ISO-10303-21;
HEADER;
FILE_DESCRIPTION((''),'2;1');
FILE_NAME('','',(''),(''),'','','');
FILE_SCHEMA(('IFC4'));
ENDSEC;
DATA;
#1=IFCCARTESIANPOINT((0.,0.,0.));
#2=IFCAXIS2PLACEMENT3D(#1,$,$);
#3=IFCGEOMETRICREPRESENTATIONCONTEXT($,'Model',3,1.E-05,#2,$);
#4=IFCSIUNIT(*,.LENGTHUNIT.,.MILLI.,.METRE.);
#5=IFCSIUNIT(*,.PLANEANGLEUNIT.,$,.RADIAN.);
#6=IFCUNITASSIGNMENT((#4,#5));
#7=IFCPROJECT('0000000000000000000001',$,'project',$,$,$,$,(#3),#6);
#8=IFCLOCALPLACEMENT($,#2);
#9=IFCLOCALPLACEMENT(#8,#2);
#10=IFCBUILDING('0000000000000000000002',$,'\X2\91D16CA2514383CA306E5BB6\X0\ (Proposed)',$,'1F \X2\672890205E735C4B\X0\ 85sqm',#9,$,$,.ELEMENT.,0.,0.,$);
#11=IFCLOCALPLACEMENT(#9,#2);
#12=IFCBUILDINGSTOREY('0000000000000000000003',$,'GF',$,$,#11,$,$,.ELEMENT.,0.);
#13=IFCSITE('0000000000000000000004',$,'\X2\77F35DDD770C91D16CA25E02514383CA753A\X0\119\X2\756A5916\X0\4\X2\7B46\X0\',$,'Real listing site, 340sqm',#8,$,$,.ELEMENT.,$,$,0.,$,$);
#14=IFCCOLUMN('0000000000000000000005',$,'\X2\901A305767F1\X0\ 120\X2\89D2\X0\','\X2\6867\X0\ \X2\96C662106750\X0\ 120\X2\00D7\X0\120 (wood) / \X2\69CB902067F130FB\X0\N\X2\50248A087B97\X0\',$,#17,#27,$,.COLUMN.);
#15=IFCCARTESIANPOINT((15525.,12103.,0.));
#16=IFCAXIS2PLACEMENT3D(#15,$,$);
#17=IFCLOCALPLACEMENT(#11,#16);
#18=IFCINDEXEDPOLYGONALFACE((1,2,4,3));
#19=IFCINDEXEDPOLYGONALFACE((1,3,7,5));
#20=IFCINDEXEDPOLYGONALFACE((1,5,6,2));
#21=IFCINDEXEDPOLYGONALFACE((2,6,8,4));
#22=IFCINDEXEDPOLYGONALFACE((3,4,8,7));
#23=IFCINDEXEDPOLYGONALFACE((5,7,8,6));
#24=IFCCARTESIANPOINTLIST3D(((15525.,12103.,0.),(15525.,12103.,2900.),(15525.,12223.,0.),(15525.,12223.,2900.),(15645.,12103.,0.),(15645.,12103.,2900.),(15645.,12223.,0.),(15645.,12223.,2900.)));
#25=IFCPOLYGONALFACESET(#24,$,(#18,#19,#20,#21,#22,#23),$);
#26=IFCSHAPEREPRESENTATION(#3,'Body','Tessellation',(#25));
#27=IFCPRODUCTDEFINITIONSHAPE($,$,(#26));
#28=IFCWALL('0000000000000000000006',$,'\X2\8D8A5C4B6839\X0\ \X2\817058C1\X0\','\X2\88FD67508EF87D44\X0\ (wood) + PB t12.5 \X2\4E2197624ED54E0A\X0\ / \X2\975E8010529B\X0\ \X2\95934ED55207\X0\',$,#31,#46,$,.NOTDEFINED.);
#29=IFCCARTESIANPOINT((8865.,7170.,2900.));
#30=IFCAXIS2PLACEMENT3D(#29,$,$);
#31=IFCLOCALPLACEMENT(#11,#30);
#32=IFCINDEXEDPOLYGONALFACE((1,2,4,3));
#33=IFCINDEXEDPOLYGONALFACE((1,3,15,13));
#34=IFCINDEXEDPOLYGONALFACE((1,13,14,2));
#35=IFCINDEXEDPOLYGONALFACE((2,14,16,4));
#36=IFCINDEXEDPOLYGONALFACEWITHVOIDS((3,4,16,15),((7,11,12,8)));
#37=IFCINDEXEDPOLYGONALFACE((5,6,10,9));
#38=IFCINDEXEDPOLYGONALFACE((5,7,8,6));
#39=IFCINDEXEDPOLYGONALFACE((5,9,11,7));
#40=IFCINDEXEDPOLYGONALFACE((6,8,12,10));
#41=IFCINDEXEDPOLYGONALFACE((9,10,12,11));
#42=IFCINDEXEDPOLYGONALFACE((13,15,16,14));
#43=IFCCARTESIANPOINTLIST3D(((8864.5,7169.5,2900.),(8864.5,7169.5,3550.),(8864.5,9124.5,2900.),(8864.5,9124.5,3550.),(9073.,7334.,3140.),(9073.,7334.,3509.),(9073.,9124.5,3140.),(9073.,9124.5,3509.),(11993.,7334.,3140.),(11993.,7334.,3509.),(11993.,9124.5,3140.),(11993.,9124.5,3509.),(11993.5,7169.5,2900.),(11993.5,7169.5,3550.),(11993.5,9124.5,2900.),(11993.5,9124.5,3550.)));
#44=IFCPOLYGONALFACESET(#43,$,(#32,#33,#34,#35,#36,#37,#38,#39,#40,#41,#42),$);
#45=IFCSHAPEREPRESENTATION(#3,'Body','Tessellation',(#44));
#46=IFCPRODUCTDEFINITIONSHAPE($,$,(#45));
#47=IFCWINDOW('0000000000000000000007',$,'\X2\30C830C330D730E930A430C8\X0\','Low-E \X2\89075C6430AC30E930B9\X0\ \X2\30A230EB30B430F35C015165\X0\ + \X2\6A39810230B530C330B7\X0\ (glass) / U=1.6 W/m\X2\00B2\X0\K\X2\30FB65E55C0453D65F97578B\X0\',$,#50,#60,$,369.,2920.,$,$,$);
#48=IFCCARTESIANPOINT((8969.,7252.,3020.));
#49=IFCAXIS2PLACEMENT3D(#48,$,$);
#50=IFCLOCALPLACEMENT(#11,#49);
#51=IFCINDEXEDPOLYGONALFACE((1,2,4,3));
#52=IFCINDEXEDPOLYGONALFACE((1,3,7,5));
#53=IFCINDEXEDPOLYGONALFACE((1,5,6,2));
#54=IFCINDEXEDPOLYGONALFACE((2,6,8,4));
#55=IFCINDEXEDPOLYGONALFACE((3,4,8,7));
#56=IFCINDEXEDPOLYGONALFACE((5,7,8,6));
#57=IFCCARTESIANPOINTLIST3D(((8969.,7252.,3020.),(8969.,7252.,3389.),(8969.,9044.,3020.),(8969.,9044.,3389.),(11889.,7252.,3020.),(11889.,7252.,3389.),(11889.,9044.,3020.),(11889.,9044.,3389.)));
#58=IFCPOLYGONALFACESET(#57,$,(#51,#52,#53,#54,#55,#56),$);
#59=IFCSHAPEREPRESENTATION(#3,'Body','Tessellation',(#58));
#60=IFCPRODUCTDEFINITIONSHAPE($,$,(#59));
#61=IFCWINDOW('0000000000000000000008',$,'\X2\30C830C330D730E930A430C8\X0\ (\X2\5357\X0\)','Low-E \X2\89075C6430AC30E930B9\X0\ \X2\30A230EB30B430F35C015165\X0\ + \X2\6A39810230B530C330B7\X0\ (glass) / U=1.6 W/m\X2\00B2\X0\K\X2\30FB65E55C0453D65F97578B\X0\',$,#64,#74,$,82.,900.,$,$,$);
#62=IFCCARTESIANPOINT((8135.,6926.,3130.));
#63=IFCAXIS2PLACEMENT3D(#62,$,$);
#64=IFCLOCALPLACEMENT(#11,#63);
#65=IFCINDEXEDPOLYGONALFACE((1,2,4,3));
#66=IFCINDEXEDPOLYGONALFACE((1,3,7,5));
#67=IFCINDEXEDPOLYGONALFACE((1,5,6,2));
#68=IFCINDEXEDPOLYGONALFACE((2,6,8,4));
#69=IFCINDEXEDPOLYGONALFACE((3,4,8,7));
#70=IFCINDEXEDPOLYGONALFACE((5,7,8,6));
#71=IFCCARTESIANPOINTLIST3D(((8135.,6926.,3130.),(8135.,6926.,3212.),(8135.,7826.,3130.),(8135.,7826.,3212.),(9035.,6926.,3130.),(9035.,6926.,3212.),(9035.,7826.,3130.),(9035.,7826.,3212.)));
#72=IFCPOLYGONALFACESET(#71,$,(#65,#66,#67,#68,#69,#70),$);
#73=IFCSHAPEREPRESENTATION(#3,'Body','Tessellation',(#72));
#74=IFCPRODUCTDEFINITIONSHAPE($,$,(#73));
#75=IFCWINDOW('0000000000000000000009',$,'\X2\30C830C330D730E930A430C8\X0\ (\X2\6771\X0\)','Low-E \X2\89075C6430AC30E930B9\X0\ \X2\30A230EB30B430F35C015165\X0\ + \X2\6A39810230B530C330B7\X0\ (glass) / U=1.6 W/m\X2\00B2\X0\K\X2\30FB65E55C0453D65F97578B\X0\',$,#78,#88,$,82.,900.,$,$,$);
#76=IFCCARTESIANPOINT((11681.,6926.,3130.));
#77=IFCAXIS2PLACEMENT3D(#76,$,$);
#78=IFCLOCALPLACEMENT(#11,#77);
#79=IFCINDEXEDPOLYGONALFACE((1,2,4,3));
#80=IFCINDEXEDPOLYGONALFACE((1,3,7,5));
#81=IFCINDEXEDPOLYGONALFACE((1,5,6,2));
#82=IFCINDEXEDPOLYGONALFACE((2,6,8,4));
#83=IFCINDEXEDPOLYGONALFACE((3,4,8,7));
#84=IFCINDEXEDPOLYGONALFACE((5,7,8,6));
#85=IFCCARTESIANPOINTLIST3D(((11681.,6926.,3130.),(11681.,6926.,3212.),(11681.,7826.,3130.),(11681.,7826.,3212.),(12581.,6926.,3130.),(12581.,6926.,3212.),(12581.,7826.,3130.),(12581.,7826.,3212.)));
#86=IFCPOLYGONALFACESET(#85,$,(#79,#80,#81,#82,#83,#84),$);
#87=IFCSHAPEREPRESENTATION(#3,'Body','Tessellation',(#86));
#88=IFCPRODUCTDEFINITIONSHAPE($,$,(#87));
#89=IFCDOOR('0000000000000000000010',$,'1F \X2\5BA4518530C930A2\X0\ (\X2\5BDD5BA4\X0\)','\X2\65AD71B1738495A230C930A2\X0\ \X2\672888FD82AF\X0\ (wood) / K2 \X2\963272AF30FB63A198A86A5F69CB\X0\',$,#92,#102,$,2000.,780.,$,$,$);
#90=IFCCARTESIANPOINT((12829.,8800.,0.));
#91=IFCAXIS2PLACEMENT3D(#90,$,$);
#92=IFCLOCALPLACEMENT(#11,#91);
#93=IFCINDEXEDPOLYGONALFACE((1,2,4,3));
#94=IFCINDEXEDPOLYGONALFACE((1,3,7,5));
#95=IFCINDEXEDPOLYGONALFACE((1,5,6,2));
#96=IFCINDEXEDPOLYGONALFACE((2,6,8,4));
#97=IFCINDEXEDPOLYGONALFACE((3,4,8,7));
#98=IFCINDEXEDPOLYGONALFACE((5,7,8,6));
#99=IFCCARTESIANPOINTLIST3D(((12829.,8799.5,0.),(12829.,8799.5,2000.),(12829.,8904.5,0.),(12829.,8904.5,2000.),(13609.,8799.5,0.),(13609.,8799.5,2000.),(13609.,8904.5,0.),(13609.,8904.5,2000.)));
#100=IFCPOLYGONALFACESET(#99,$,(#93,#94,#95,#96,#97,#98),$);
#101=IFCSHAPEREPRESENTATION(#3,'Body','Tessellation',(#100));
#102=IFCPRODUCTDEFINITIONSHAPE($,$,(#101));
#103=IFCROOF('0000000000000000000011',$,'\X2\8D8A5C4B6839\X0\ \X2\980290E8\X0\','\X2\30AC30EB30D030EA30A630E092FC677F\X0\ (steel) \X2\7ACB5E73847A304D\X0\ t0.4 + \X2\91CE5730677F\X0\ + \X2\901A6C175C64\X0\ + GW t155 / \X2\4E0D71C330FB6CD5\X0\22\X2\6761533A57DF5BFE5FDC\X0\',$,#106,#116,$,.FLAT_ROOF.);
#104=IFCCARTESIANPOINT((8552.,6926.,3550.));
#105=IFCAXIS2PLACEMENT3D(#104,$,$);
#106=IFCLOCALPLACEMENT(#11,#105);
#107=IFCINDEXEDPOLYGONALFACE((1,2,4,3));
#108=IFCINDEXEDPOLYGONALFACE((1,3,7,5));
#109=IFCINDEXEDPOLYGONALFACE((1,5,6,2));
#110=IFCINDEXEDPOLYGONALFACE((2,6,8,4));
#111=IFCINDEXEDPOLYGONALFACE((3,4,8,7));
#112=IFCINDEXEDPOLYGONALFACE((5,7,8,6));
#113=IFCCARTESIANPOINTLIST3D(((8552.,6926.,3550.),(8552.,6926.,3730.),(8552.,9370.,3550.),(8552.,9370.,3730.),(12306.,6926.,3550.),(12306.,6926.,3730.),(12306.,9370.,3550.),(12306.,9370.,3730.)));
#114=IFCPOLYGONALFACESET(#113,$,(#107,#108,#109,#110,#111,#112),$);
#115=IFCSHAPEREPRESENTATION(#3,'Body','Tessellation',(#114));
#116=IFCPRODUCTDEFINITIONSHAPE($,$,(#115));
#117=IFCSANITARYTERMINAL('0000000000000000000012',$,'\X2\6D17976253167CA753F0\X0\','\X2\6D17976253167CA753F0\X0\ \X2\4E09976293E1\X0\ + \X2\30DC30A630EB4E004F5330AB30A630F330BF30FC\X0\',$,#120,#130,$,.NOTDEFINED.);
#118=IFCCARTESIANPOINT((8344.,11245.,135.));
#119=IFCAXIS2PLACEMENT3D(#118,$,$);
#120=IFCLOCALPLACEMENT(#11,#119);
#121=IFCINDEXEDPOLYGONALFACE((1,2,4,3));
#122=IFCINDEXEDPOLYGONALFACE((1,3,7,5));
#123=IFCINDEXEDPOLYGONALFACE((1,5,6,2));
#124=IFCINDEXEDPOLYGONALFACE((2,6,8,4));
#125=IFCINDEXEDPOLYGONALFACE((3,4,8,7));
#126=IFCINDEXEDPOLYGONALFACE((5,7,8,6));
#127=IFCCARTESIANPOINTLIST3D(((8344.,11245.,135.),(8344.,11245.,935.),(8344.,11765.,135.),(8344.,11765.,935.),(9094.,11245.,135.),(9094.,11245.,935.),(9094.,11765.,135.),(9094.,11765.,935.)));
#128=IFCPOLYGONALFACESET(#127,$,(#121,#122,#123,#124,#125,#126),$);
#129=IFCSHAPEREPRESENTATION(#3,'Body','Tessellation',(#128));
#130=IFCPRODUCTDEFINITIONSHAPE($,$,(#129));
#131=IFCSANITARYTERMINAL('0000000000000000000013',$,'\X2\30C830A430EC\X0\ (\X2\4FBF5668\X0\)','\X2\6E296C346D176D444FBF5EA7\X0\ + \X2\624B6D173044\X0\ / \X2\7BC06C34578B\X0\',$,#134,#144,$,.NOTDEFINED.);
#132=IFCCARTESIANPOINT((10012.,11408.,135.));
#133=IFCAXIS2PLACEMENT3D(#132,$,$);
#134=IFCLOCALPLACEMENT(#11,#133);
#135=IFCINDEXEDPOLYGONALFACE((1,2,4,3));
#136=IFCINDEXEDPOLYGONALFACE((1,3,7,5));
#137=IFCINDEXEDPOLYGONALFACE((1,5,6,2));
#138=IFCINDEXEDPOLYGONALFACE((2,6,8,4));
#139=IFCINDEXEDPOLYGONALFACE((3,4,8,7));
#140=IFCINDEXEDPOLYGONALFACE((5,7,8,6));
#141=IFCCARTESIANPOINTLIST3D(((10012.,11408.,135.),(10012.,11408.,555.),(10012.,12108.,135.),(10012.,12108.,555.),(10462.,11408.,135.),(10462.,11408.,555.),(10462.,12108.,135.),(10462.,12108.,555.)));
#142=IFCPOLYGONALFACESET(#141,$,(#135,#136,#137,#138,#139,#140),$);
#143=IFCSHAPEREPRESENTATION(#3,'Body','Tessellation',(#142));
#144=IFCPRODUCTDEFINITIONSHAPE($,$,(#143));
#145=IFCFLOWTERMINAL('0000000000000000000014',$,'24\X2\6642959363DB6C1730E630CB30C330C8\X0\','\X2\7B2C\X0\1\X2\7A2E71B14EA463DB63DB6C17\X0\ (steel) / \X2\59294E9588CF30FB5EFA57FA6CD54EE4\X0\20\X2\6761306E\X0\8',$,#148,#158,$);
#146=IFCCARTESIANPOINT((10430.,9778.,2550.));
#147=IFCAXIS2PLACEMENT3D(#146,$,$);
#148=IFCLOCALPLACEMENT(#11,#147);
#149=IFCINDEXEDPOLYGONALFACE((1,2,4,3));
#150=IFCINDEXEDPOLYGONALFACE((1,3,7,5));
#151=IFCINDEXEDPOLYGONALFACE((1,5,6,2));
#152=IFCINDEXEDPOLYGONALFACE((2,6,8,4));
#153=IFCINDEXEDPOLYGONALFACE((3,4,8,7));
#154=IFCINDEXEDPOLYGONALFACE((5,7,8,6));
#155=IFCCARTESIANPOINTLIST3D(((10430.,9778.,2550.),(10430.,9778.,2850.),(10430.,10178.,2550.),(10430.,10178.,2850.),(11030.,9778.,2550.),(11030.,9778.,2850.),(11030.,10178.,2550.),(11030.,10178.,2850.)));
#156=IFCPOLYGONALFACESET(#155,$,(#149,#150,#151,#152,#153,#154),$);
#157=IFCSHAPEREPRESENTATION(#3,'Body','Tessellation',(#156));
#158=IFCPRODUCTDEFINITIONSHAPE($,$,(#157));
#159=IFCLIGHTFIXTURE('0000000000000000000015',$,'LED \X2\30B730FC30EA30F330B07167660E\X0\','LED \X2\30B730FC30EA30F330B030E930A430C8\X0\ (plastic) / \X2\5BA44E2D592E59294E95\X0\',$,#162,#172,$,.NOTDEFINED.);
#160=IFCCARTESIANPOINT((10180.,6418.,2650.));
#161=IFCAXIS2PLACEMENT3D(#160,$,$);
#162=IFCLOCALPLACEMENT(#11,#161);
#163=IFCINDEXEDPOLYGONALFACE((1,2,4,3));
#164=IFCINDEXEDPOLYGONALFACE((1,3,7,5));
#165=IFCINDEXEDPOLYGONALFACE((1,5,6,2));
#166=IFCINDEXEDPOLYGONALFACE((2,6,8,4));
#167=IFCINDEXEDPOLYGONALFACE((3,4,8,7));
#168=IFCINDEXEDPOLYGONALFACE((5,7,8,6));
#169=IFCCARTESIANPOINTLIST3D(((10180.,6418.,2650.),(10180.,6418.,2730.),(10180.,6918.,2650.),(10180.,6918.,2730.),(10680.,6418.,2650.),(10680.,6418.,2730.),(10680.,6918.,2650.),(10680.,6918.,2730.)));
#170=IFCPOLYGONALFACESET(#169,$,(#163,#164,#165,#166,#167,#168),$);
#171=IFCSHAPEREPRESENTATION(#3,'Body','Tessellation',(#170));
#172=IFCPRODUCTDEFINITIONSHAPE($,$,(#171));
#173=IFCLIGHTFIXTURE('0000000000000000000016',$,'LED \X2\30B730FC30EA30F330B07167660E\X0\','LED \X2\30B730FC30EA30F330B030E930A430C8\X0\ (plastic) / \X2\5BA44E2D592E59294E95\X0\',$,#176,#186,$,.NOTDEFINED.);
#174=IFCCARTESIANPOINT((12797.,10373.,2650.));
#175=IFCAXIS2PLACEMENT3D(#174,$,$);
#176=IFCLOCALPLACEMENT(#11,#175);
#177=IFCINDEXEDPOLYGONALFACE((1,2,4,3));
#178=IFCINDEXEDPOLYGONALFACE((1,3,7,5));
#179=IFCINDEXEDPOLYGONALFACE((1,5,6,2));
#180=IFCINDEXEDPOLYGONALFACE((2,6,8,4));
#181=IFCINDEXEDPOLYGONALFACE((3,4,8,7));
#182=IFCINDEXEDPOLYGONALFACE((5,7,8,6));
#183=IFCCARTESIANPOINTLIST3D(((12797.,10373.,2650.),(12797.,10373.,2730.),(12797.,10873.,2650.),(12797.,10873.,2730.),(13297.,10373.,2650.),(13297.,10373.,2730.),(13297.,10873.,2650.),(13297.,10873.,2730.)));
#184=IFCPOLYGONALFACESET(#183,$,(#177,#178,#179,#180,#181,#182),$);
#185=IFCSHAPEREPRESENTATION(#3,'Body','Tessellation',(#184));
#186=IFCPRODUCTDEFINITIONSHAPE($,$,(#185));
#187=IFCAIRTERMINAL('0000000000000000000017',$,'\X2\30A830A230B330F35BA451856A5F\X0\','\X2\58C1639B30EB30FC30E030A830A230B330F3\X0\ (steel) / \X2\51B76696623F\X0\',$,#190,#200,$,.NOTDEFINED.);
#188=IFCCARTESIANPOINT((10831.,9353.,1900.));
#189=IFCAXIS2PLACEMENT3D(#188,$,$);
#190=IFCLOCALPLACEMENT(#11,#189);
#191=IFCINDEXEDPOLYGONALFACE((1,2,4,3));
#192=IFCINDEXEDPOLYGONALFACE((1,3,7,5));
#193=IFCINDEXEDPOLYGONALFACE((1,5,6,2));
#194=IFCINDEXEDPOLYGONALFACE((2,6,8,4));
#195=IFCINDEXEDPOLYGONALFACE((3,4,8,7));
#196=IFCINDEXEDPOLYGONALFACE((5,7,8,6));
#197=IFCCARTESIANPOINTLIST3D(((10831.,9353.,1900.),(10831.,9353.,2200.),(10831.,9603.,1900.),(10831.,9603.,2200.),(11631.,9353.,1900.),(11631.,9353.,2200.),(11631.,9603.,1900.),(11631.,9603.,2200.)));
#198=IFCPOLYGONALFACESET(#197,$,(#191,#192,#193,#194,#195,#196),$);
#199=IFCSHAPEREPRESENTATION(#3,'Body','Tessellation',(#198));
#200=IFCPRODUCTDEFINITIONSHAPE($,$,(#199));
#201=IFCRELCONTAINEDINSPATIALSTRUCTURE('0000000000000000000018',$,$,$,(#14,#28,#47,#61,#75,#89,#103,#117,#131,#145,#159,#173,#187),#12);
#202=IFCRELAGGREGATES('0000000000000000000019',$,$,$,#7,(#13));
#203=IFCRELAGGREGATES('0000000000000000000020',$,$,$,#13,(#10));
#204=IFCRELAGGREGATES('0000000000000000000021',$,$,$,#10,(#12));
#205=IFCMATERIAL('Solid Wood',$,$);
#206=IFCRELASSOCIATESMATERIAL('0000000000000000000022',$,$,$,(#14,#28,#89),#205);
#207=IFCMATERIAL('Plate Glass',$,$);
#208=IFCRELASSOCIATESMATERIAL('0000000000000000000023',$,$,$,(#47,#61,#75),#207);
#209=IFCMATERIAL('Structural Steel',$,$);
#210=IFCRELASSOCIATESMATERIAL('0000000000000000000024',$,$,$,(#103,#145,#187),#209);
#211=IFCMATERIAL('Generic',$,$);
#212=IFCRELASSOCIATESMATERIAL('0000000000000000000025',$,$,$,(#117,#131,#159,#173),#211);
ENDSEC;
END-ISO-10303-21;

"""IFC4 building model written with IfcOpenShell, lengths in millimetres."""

from ifc_helpers import new_model, si_unit, frame, frame_2d, origin, place, context, project, spatial, rectangle, extrude, material, element, fill, save


model = new_model("IFC4")

# Units and contexts
model_context = context("Model", 3, precision=1e-05, world=origin())
ifc_project = project(units=[si_unit("LENGTHUNIT", "METRE", prefix="MILLI"), si_unit("PLANEANGLEUNIT", "RADIAN")], contexts=[model_context])

# Site, building, storey
site_placement = place(None, origin())
site = spatial("IfcSite", under=ifc_project, at=site_placement, Name="石川県金沢市元菊町119番外4筆", ObjectType="Real listing site, 340sqm", CompositionType="ELEMENT", RefElevation=0.0)
building_placement = place(site_placement, origin())
building = spatial("IfcBuilding", under=site, at=building_placement, Name="金沢元菊の家 (Proposed)", ObjectType="1F 木造平屋 85sqm", CompositionType="ELEMENT", ElevationOfRefHeight=0.0, ElevationOfTerrain=0.0)
storey_placement = place(building_placement, origin())
storey = spatial("IfcBuildingStorey", under=building, at=storey_placement, Name="GF", CompositionType="ELEMENT", Elevation=0.0)

# Column
ifc_material_1 = material(Name="Solid Wood")
column_1_placement = place(storey_placement, frame((15525.0, 12103.0, 0.0)))
element("IfcColumn", 1, at=column_1_placement, inside=storey, material=ifc_material_1, Name="通し柱 120角", Description="桧 集成材 120×120 (wood) / 構造柱・N値計算", PredefinedType="COLUMN", context=model_context, shape_type="SweptSolid", body=[
    extrude(rectangle(XDim=120.0, YDim=120.0, at=frame_2d((60.0, 60.0))), frame((15525.0, 12103.0, 0.0)), (0.0, 0.0, 1.0), 2900.0),
])

# Wall, openings, windows
wall_1_placement = place(storey_placement, frame((8865.0, 7170.0, 2900.0)))
wall_1 = element("IfcWall", 2, at=wall_1_placement, inside=storey, material=ifc_material_1, Name="越屋根 腰壁", Description="製材軸組 (wood) + PB t12.5 両面仕上 / 非耐力 間仕切", PredefinedType="NOTDEFINED", context=model_context, shape_type="SweptSolid", body=[
    extrude(rectangle(XDim=3129.0, YDim=1955.0, at=frame_2d((1564.0, 977.0))), frame((8865.0, 7170.0, 2900.0)), (0.0, 0.0, 1.0), 650.0),
])
opening_1_placement = place(storey_placement, frame((8969.0, 7252.0, 3020.0)))
opening_1 = element("IfcOpeningElement", 3, at=opening_1_placement, cuts=wall_1, PredefinedType="NOTDEFINED", context=model_context, shape_type="SweptSolid", body=[
    extrude(rectangle(XDim=2920.0, YDim=1792.0, at=frame_2d((1460.0, 896.0))), frame((8969.0, 7252.0, 3020.0)), (0.0, 0.0, 1.0), 369.0),
])
opening_2_placement = place(storey_placement, frame((8135.0, 6926.0, 3130.0)))
opening_2 = element("IfcOpeningElement", 4, at=opening_2_placement, cuts=wall_1, PredefinedType="NOTDEFINED", context=model_context, shape_type="SweptSolid", body=[
    extrude(rectangle(XDim=900.0, YDim=900.0, at=frame_2d((450.0, 450.0))), frame((8135.0, 6926.0, 3130.0)), (0.0, 0.0, 1.0), 82.0),
])
opening_3_placement = place(storey_placement, frame((11681.0, 6926.0, 3130.0)))
opening_3 = element("IfcOpeningElement", 5, at=opening_3_placement, cuts=wall_1, PredefinedType="NOTDEFINED", context=model_context, shape_type="SweptSolid", body=[
    extrude(rectangle(XDim=900.0, YDim=900.0, at=frame_2d((450.0, 450.0))), frame((11681.0, 6926.0, 3130.0)), (0.0, 0.0, 1.0), 82.0),
])
ifc_material_2 = material(Name="Plate Glass")
window_1_placement = place(storey_placement, frame((8969.0, 7252.0, 3020.0)))
window_1 = element("IfcWindow", 6, at=window_1_placement, inside=storey, material=ifc_material_2, Name="トップライト", Description="Low-E 複層ガラス アルゴン封入 + 樹脂サッシ (glass) / U=1.6 W/m²K・日射取得型", OverallHeight=369.0, OverallWidth=2920.0, context=model_context, shape_type="SweptSolid", body=[
    extrude(rectangle(XDim=2920.0, YDim=1792.0, at=frame_2d((1460.0, 896.0))), frame((8969.0, 7252.0, 3020.0)), (0.0, 0.0, 1.0), 369.0),
])
fill(opening_1, window_1)
window_2_placement = place(storey_placement, frame((8135.0, 6926.0, 3130.0)))
window_2 = element("IfcWindow", 7, at=window_2_placement, inside=storey, material=ifc_material_2, Name="トップライト (南)", Description="Low-E 複層ガラス アルゴン封入 + 樹脂サッシ (glass) / U=1.6 W/m²K・日射取得型", OverallHeight=82.0, OverallWidth=900.0, context=model_context, shape_type="SweptSolid", body=[
    extrude(rectangle(XDim=900.0, YDim=900.0, at=frame_2d((450.0, 450.0))), frame((8135.0, 6926.0, 3130.0)), (0.0, 0.0, 1.0), 82.0),
])
fill(opening_2, window_2)
window_3_placement = place(storey_placement, frame((11681.0, 6926.0, 3130.0)))
window_3 = element("IfcWindow", 8, at=window_3_placement, inside=storey, material=ifc_material_2, Name="トップライト (東)", Description="Low-E 複層ガラス アルゴン封入 + 樹脂サッシ (glass) / U=1.6 W/m²K・日射取得型", OverallHeight=82.0, OverallWidth=900.0, context=model_context, shape_type="SweptSolid", body=[
    extrude(rectangle(XDim=900.0, YDim=900.0, at=frame_2d((450.0, 450.0))), frame((11681.0, 6926.0, 3130.0)), (0.0, 0.0, 1.0), 82.0),
])
fill(opening_3, window_3)

# Door
door_placement = place(storey_placement, frame((12829.0, 8800.0, 0.0)))
element("IfcDoor", 9, at=door_placement, inside=storey, material=ifc_material_1, Name="1F 室内ドア (寝室)", Description="断熱玄関ドア 木製芯 (wood) / K2 防犯・採風機構", OverallHeight=2000.0, OverallWidth=780.0, context=model_context, shape_type="SweptSolid", body=[
    extrude(rectangle(XDim=780.0, YDim=105.0, at=frame_2d((390.0, 52.0))), frame((12829.0, 8800.0, 0.0)), (0.0, 0.0, 1.0), 2000.0),
])

# Roof
ifc_material_3 = material(Name="Structural Steel")
roof_placement = place(storey_placement, frame((8552.0, 6926.0, 3550.0)))
element("IfcRoof", 10, at=roof_placement, inside=storey, material=ifc_material_3, Name="越屋根 頂部", Description="ガルバリウム鋼板 (steel) 立平葺き t0.4 + 野地板 + 通気層 + GW t155 / 不燃・法22条区域対応", PredefinedType="FLAT_ROOF", context=model_context, shape_type="SweptSolid", body=[
    extrude(rectangle(XDim=3754.0, YDim=2444.0, at=frame_2d((1877.0, 1222.0))), frame((8552.0, 6926.0, 3550.0)), (0.0, 0.0, 1.0), 180.0),
])

# Sanitary terminals
ifc_material_4 = material(Name="Generic")
sanitary_terminal_1_placement = place(storey_placement, frame((8344.0, 11245.0, 135.0)))
element("IfcSanitaryTerminal", 11, at=sanitary_terminal_1_placement, inside=storey, material=ifc_material_4, Name="洗面化粧台", Description="洗面化粧台 三面鏡 + ボウル一体カウンター", PredefinedType="NOTDEFINED", context=model_context, shape_type="SweptSolid", body=[
    extrude(rectangle(XDim=750.0, YDim=520.0, at=frame_2d((375.0, 260.0))), frame((8344.0, 11245.0, 135.0)), (0.0, 0.0, 1.0), 800.0),
])
sanitary_terminal_2_placement = place(storey_placement, frame((10012.0, 11408.0, 135.0)))
element("IfcSanitaryTerminal", 12, at=sanitary_terminal_2_placement, inside=storey, material=ifc_material_4, Name="トイレ (便器)", Description="温水洗浄便座 + 手洗い / 節水型", PredefinedType="NOTDEFINED", context=model_context, shape_type="SweptSolid", body=[
    extrude(rectangle(XDim=450.0, YDim=700.0, at=frame_2d((225.0, 350.0))), frame((10012.0, 11408.0, 135.0)), (0.0, 0.0, 1.0), 420.0),
])

# Flow terminal
flow_terminal_placement = place(storey_placement, frame((10430.0, 9778.0, 2550.0)))
element("IfcFlowTerminal", 13, at=flow_terminal_placement, inside=storey, material=ifc_material_3, Name="24時間換気ユニット", Description="第1種熱交換換気 (steel) / 天井裏・建基法令20条の8", context=model_context, shape_type="SweptSolid", body=[
    extrude(rectangle(XDim=600.0, YDim=400.0, at=frame_2d((300.0, 200.0))), frame((10430.0, 9778.0, 2550.0)), (0.0, 0.0, 1.0), 300.0),
])

# Light fixtures
light_fixture_1_placement = place(storey_placement, frame((10180.0, 6418.0, 2650.0)))
element("IfcLightFixture", 14, at=light_fixture_1_placement, inside=storey, material=ifc_material_4, Name="LED シーリング照明", Description="LED シーリングライト (plastic) / 室中央天井", PredefinedType="NOTDEFINED", context=model_context, shape_type="SweptSolid", body=[
    extrude(rectangle(XDim=500.0, YDim=500.0, at=frame_2d((250.0, 250.0))), frame((10180.0, 6418.0, 2650.0)), (0.0, 0.0, 1.0), 80.0),
])
light_fixture_2_placement = place(storey_placement, frame((12797.0, 10373.0, 2650.0)))
element("IfcLightFixture", 15, at=light_fixture_2_placement, inside=storey, material=ifc_material_4, Name="LED シーリング照明", Description="LED シーリングライト (plastic) / 室中央天井", PredefinedType="NOTDEFINED", context=model_context, shape_type="SweptSolid", body=[
    extrude(rectangle(XDim=500.0, YDim=500.0, at=frame_2d((250.0, 250.0))), frame((12797.0, 10373.0, 2650.0)), (0.0, 0.0, 1.0), 80.0),
])

# Air terminal
air_terminal_placement = place(storey_placement, frame((10831.0, 9353.0, 1900.0)))
element("IfcAirTerminal", 16, at=air_terminal_placement, inside=storey, material=ifc_material_3, Name="エアコン室内機", Description="壁掛ルームエアコン (steel) / 冷暖房", PredefinedType="NOTDEFINED", context=model_context, shape_type="SweptSolid", body=[
    extrude(rectangle(XDim=800.0, YDim=250.0, at=frame_2d((400.0, 125.0))), frame((10831.0, 9353.0, 1900.0)), (0.0, 0.0, 1.0), 300.0),
])

save(model, "model.ifc")
